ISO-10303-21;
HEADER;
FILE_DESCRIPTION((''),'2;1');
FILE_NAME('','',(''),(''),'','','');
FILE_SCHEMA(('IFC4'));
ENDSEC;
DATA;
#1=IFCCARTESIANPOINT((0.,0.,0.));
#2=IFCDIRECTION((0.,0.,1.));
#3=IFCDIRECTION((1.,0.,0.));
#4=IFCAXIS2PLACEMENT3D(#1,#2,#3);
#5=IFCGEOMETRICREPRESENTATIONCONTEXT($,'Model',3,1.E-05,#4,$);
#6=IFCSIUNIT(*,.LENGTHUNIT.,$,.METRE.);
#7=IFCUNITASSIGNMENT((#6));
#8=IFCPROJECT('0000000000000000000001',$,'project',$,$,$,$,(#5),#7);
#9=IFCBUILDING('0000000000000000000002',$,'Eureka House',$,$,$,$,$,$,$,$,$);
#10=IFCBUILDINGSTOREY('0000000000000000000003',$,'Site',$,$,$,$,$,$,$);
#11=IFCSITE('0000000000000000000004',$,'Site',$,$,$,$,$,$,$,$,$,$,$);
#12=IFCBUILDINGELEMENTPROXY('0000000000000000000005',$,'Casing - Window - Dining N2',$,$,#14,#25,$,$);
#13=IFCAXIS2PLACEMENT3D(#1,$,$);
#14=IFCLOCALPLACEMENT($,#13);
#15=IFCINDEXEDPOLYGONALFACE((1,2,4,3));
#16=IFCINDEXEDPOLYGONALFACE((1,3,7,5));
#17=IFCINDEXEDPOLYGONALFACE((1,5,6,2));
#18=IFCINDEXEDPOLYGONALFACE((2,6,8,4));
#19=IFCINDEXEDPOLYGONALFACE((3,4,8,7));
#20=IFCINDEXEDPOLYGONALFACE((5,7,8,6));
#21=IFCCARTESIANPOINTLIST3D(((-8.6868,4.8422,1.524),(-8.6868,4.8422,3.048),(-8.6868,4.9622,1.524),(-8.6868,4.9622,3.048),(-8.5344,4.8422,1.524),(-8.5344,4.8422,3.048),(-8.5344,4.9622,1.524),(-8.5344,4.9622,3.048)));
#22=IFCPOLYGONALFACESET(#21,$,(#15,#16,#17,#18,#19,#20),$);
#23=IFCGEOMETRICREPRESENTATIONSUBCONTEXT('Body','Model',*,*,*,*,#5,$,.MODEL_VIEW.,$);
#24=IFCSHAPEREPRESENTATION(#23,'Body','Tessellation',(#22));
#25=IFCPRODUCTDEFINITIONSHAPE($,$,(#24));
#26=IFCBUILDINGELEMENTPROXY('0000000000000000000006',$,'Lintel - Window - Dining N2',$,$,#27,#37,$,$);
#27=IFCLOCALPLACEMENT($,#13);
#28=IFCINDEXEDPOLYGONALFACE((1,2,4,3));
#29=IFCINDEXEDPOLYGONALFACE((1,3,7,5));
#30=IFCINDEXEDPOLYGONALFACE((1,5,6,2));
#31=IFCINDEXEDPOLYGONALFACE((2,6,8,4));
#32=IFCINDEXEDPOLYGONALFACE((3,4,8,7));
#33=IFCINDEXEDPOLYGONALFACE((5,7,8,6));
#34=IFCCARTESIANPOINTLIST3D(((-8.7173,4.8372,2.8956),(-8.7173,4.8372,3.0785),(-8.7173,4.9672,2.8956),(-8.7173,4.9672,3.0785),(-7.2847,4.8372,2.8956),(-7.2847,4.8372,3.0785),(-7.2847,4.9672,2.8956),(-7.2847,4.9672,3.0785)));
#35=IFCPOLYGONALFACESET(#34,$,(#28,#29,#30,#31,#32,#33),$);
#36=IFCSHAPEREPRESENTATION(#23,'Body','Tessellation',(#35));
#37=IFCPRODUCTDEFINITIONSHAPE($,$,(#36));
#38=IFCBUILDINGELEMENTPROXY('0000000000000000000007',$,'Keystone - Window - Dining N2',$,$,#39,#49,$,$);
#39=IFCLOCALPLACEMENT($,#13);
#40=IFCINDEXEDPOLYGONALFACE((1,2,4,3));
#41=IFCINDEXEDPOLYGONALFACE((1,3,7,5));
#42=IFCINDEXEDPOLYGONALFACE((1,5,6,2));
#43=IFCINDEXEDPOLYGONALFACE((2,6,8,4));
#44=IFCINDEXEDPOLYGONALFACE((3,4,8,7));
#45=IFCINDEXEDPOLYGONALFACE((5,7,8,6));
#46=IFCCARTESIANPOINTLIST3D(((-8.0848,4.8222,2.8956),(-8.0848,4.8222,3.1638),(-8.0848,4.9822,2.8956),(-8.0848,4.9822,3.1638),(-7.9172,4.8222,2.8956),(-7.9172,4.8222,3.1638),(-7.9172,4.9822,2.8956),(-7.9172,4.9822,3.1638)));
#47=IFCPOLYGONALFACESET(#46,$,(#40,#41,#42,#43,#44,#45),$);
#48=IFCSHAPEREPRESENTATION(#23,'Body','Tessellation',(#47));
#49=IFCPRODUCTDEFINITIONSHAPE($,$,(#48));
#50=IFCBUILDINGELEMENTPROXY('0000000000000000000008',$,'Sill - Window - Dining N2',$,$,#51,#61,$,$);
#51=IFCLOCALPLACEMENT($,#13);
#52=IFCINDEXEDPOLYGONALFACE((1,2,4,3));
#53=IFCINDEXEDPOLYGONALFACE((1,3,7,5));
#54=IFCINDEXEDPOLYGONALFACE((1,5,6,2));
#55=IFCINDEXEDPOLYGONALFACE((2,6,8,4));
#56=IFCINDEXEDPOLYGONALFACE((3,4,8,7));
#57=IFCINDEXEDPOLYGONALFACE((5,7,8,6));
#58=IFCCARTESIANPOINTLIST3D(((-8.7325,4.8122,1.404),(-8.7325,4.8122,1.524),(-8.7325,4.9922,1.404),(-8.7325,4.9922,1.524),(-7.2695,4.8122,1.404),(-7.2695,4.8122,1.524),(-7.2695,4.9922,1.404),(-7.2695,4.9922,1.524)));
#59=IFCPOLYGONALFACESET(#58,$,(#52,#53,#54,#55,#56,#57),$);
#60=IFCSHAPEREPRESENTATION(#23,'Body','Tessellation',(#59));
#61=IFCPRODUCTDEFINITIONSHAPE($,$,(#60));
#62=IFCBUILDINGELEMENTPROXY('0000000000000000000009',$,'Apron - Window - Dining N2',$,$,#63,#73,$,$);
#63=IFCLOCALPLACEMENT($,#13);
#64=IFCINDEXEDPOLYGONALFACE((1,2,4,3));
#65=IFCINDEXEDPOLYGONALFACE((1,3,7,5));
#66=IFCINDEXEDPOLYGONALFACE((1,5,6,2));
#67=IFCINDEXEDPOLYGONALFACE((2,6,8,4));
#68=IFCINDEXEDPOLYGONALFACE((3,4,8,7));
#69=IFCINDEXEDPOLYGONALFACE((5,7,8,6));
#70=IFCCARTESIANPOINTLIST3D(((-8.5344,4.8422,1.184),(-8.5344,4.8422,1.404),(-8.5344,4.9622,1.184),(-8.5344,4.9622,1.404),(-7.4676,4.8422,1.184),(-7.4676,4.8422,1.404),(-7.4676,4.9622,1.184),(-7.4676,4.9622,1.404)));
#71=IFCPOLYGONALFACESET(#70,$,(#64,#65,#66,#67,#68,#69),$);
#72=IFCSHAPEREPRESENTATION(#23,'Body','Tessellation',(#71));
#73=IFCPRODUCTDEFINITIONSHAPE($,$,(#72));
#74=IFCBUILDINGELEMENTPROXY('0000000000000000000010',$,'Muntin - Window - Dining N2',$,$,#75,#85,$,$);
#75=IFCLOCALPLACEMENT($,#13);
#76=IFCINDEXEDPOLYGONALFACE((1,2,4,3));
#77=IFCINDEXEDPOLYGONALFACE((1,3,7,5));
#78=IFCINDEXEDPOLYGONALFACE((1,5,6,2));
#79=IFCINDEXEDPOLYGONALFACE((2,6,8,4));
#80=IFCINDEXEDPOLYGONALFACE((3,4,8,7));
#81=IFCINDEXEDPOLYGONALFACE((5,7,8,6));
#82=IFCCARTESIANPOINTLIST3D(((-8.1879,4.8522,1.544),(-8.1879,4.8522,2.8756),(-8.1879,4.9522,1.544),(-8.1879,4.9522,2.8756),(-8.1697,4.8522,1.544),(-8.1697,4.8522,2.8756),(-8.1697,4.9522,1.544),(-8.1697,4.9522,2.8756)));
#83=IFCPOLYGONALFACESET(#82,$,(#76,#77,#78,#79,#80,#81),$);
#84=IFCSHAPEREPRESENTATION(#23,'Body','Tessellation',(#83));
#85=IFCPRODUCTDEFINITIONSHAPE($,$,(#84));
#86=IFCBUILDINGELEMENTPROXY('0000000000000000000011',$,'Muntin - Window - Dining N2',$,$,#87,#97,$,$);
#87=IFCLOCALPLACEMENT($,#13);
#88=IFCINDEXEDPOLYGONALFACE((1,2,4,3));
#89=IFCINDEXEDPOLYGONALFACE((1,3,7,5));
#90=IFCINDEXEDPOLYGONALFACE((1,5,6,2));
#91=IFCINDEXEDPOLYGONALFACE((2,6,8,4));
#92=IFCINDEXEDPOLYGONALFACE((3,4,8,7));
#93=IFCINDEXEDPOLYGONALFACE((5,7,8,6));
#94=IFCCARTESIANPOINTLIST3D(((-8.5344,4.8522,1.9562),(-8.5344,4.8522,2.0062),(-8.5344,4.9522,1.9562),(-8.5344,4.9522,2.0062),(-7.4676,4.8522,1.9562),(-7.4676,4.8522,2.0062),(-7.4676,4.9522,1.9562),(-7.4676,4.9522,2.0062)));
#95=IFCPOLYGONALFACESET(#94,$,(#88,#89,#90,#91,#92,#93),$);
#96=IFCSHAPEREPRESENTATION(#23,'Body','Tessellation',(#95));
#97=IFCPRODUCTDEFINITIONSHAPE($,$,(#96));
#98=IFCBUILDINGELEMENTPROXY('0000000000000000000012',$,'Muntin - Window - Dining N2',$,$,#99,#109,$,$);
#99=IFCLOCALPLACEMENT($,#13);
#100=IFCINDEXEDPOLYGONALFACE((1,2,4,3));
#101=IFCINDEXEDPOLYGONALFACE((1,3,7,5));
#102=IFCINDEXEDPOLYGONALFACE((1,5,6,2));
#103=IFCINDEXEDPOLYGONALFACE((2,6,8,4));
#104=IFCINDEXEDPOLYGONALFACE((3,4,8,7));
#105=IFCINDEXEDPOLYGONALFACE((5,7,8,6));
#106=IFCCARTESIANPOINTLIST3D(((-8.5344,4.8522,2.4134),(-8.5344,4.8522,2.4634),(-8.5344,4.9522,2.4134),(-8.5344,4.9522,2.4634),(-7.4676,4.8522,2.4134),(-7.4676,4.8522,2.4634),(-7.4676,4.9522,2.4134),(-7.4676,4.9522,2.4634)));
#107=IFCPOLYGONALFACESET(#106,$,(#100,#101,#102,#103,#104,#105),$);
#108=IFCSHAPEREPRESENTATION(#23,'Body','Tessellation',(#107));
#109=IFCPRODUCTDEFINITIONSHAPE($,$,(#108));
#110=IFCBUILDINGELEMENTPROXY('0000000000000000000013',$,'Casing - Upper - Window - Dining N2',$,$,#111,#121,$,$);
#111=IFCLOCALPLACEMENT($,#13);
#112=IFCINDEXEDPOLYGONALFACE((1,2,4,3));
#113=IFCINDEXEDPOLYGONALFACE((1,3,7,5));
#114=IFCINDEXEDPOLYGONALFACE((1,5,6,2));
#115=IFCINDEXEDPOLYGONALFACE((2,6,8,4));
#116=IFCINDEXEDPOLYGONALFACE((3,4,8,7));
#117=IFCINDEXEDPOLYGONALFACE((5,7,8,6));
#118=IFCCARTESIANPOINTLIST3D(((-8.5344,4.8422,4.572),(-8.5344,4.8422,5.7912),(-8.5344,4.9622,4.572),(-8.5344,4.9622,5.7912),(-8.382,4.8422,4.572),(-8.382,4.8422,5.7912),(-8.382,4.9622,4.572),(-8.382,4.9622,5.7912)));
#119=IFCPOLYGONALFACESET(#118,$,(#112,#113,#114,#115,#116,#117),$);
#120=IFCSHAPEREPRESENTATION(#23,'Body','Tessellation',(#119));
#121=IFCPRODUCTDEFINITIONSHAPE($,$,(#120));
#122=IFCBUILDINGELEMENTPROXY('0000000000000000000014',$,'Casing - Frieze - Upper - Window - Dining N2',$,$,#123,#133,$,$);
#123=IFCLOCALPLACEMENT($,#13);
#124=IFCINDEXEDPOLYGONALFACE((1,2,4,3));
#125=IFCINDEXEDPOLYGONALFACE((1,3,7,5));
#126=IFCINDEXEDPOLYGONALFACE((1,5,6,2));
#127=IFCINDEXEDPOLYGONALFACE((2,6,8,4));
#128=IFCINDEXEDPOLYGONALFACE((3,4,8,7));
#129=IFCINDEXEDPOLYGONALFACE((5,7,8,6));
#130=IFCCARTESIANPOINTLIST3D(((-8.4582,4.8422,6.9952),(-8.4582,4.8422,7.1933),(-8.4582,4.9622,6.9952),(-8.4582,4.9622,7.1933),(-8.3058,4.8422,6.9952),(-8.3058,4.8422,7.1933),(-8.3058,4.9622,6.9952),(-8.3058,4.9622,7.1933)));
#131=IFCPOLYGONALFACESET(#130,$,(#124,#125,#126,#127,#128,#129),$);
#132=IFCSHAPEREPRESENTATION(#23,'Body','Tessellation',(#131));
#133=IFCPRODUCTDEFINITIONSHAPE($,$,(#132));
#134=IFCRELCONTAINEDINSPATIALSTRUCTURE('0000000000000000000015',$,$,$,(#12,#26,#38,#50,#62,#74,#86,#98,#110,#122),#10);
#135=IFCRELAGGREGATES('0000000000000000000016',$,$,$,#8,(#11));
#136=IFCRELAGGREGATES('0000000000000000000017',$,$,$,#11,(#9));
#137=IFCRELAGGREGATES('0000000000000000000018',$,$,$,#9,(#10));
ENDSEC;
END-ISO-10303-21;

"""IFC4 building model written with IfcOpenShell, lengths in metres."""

from ifc_helpers import new_model, si_unit, frame, origin, origin_with_axes, origin_2d, place, context, subcontext, project, spatial, rectangle, extrude, element, save


model = new_model("IFC4")

# Units and contexts
model_context = context("Model", 3, precision=1e-05, world=origin_with_axes())
body_context = subcontext(model_context, "Body", "Model", "MODEL_VIEW")
ifc_project = project(units=[si_unit("LENGTHUNIT", "METRE")], contexts=[model_context])

# Site, building, storey
site = spatial("IfcSite", under=ifc_project, Name="Site")
building = spatial("IfcBuilding", under=site, Name="Eureka House")
storey = spatial("IfcBuildingStorey", under=building, Name="Site")

# Building element proxies
proxy_1_placement = place(None, frame((-8.6106, 4.9022, 1.524), z_axis=(0.0, 0.0, 1.0), x_axis=(1.0, 0.0, 0.0)))
element("IfcBuildingElementProxy", 1, at=proxy_1_placement, inside=storey, Name="Casing - Window - Dining N2", context=body_context, shape_type="SweptSolid", body=[
    extrude(rectangle(XDim=0.1524, YDim=0.12, at=origin_2d()), origin(), (0.0, 0.0, 1.0), 1.524),
])
proxy_2_placement = place(None, frame((-8.001, 4.9022, 2.8956), z_axis=(0.0, 0.0, 1.0), x_axis=(1.0, 0.0, 0.0)))
element("IfcBuildingElementProxy", 2, at=proxy_2_placement, inside=storey, Name="Lintel - Window - Dining N2", context=body_context, shape_type="SweptSolid", body=[
    extrude(rectangle(XDim=1.4326, YDim=0.13, at=origin_2d()), origin(), (0.0, 0.0, 1.0), 0.1829),
])
proxy_3_placement = place(None, frame((-8.001, 4.9022, 2.8956), z_axis=(0.0, 0.0, 1.0), x_axis=(1.0, 0.0, 0.0)))
element("IfcBuildingElementProxy", 3, at=proxy_3_placement, inside=storey, Name="Keystone - Window - Dining N2", context=body_context, shape_type="SweptSolid", body=[
    extrude(rectangle(XDim=0.1676, YDim=0.16, at=origin_2d()), origin(), (0.0, 0.0, 1.0), 0.2682),
])
proxy_4_placement = place(None, frame((-8.001, 4.9022, 1.404), z_axis=(0.0, 0.0, 1.0), x_axis=(1.0, 0.0, 0.0)))
element("IfcBuildingElementProxy", 4, at=proxy_4_placement, inside=storey, Name="Sill - Window - Dining N2", context=body_context, shape_type="SweptSolid", body=[
    extrude(rectangle(XDim=1.463, YDim=0.18, at=origin_2d()), origin(), (0.0, 0.0, 1.0), 0.12),
])
proxy_5_placement = place(None, frame((-8.001, 4.9022, 1.184), z_axis=(0.0, 0.0, 1.0), x_axis=(1.0, 0.0, 0.0)))
element("IfcBuildingElementProxy", 5, at=proxy_5_placement, inside=storey, Name="Apron - Window - Dining N2", context=body_context, shape_type="SweptSolid", body=[
    extrude(rectangle(XDim=1.0668, YDim=0.12, at=origin_2d()), origin(), (0.0, 0.0, 1.0), 0.22),
])
proxy_6_placement = place(None, frame((-8.1788, 4.9022, 1.544), z_axis=(0.0, 0.0, 1.0), x_axis=(1.0, 0.0, 0.0)))
element("IfcBuildingElementProxy", 6, at=proxy_6_placement, inside=storey, Name="Muntin - Window - Dining N2", context=body_context, shape_type="SweptSolid", body=[
    extrude(rectangle(XDim=0.0183, YDim=0.1, at=origin_2d()), origin(), (0.0, 0.0, 1.0), 1.3316),
])
proxy_7_placement = place(None, frame((-8.001, 4.9022, 1.9562), z_axis=(0.0, 0.0, 1.0), x_axis=(1.0, 0.0, 0.0)))
element("IfcBuildingElementProxy", 7, at=proxy_7_placement, inside=storey, Name="Muntin - Window - Dining N2", context=body_context, shape_type="SweptSolid", body=[
    extrude(rectangle(XDim=1.0668, YDim=0.1, at=origin_2d()), origin(), (0.0, 0.0, 1.0), 0.05),
])
proxy_8_placement = place(None, frame((-8.001, 4.9022, 2.4134), z_axis=(0.0, 0.0, 1.0), x_axis=(1.0, 0.0, 0.0)))
element("IfcBuildingElementProxy", 8, at=proxy_8_placement, inside=storey, Name="Muntin - Window - Dining N2", context=body_context, shape_type="SweptSolid", body=[
    extrude(rectangle(XDim=1.0668, YDim=0.1, at=origin_2d()), origin(), (0.0, 0.0, 1.0), 0.05),
])
proxy_9_placement = place(None, frame((-8.4582, 4.9022, 4.572), z_axis=(0.0, 0.0, 1.0), x_axis=(1.0, 0.0, 0.0)))
element("IfcBuildingElementProxy", 9, at=proxy_9_placement, inside=storey, Name="Casing - Upper - Window - Dining N2", context=body_context, shape_type="SweptSolid", body=[
    extrude(rectangle(XDim=0.1524, YDim=0.12, at=origin_2d()), origin(), (0.0, 0.0, 1.0), 1.2192),
])
proxy_10_placement = place(None, frame((-8.382, 4.9022, 6.9952), z_axis=(0.0, 0.0, 1.0), x_axis=(1.0, 0.0, 0.0)))
element("IfcBuildingElementProxy", 10, at=proxy_10_placement, inside=storey, Name="Casing - Frieze - Upper - Window - Dining N2", context=body_context, shape_type="SweptSolid", body=[
    extrude(rectangle(XDim=0.1524, YDim=0.12, at=origin_2d()), origin(), (0.0, 0.0, 1.0), 0.1981),
])

save(model, "model.ifc")
